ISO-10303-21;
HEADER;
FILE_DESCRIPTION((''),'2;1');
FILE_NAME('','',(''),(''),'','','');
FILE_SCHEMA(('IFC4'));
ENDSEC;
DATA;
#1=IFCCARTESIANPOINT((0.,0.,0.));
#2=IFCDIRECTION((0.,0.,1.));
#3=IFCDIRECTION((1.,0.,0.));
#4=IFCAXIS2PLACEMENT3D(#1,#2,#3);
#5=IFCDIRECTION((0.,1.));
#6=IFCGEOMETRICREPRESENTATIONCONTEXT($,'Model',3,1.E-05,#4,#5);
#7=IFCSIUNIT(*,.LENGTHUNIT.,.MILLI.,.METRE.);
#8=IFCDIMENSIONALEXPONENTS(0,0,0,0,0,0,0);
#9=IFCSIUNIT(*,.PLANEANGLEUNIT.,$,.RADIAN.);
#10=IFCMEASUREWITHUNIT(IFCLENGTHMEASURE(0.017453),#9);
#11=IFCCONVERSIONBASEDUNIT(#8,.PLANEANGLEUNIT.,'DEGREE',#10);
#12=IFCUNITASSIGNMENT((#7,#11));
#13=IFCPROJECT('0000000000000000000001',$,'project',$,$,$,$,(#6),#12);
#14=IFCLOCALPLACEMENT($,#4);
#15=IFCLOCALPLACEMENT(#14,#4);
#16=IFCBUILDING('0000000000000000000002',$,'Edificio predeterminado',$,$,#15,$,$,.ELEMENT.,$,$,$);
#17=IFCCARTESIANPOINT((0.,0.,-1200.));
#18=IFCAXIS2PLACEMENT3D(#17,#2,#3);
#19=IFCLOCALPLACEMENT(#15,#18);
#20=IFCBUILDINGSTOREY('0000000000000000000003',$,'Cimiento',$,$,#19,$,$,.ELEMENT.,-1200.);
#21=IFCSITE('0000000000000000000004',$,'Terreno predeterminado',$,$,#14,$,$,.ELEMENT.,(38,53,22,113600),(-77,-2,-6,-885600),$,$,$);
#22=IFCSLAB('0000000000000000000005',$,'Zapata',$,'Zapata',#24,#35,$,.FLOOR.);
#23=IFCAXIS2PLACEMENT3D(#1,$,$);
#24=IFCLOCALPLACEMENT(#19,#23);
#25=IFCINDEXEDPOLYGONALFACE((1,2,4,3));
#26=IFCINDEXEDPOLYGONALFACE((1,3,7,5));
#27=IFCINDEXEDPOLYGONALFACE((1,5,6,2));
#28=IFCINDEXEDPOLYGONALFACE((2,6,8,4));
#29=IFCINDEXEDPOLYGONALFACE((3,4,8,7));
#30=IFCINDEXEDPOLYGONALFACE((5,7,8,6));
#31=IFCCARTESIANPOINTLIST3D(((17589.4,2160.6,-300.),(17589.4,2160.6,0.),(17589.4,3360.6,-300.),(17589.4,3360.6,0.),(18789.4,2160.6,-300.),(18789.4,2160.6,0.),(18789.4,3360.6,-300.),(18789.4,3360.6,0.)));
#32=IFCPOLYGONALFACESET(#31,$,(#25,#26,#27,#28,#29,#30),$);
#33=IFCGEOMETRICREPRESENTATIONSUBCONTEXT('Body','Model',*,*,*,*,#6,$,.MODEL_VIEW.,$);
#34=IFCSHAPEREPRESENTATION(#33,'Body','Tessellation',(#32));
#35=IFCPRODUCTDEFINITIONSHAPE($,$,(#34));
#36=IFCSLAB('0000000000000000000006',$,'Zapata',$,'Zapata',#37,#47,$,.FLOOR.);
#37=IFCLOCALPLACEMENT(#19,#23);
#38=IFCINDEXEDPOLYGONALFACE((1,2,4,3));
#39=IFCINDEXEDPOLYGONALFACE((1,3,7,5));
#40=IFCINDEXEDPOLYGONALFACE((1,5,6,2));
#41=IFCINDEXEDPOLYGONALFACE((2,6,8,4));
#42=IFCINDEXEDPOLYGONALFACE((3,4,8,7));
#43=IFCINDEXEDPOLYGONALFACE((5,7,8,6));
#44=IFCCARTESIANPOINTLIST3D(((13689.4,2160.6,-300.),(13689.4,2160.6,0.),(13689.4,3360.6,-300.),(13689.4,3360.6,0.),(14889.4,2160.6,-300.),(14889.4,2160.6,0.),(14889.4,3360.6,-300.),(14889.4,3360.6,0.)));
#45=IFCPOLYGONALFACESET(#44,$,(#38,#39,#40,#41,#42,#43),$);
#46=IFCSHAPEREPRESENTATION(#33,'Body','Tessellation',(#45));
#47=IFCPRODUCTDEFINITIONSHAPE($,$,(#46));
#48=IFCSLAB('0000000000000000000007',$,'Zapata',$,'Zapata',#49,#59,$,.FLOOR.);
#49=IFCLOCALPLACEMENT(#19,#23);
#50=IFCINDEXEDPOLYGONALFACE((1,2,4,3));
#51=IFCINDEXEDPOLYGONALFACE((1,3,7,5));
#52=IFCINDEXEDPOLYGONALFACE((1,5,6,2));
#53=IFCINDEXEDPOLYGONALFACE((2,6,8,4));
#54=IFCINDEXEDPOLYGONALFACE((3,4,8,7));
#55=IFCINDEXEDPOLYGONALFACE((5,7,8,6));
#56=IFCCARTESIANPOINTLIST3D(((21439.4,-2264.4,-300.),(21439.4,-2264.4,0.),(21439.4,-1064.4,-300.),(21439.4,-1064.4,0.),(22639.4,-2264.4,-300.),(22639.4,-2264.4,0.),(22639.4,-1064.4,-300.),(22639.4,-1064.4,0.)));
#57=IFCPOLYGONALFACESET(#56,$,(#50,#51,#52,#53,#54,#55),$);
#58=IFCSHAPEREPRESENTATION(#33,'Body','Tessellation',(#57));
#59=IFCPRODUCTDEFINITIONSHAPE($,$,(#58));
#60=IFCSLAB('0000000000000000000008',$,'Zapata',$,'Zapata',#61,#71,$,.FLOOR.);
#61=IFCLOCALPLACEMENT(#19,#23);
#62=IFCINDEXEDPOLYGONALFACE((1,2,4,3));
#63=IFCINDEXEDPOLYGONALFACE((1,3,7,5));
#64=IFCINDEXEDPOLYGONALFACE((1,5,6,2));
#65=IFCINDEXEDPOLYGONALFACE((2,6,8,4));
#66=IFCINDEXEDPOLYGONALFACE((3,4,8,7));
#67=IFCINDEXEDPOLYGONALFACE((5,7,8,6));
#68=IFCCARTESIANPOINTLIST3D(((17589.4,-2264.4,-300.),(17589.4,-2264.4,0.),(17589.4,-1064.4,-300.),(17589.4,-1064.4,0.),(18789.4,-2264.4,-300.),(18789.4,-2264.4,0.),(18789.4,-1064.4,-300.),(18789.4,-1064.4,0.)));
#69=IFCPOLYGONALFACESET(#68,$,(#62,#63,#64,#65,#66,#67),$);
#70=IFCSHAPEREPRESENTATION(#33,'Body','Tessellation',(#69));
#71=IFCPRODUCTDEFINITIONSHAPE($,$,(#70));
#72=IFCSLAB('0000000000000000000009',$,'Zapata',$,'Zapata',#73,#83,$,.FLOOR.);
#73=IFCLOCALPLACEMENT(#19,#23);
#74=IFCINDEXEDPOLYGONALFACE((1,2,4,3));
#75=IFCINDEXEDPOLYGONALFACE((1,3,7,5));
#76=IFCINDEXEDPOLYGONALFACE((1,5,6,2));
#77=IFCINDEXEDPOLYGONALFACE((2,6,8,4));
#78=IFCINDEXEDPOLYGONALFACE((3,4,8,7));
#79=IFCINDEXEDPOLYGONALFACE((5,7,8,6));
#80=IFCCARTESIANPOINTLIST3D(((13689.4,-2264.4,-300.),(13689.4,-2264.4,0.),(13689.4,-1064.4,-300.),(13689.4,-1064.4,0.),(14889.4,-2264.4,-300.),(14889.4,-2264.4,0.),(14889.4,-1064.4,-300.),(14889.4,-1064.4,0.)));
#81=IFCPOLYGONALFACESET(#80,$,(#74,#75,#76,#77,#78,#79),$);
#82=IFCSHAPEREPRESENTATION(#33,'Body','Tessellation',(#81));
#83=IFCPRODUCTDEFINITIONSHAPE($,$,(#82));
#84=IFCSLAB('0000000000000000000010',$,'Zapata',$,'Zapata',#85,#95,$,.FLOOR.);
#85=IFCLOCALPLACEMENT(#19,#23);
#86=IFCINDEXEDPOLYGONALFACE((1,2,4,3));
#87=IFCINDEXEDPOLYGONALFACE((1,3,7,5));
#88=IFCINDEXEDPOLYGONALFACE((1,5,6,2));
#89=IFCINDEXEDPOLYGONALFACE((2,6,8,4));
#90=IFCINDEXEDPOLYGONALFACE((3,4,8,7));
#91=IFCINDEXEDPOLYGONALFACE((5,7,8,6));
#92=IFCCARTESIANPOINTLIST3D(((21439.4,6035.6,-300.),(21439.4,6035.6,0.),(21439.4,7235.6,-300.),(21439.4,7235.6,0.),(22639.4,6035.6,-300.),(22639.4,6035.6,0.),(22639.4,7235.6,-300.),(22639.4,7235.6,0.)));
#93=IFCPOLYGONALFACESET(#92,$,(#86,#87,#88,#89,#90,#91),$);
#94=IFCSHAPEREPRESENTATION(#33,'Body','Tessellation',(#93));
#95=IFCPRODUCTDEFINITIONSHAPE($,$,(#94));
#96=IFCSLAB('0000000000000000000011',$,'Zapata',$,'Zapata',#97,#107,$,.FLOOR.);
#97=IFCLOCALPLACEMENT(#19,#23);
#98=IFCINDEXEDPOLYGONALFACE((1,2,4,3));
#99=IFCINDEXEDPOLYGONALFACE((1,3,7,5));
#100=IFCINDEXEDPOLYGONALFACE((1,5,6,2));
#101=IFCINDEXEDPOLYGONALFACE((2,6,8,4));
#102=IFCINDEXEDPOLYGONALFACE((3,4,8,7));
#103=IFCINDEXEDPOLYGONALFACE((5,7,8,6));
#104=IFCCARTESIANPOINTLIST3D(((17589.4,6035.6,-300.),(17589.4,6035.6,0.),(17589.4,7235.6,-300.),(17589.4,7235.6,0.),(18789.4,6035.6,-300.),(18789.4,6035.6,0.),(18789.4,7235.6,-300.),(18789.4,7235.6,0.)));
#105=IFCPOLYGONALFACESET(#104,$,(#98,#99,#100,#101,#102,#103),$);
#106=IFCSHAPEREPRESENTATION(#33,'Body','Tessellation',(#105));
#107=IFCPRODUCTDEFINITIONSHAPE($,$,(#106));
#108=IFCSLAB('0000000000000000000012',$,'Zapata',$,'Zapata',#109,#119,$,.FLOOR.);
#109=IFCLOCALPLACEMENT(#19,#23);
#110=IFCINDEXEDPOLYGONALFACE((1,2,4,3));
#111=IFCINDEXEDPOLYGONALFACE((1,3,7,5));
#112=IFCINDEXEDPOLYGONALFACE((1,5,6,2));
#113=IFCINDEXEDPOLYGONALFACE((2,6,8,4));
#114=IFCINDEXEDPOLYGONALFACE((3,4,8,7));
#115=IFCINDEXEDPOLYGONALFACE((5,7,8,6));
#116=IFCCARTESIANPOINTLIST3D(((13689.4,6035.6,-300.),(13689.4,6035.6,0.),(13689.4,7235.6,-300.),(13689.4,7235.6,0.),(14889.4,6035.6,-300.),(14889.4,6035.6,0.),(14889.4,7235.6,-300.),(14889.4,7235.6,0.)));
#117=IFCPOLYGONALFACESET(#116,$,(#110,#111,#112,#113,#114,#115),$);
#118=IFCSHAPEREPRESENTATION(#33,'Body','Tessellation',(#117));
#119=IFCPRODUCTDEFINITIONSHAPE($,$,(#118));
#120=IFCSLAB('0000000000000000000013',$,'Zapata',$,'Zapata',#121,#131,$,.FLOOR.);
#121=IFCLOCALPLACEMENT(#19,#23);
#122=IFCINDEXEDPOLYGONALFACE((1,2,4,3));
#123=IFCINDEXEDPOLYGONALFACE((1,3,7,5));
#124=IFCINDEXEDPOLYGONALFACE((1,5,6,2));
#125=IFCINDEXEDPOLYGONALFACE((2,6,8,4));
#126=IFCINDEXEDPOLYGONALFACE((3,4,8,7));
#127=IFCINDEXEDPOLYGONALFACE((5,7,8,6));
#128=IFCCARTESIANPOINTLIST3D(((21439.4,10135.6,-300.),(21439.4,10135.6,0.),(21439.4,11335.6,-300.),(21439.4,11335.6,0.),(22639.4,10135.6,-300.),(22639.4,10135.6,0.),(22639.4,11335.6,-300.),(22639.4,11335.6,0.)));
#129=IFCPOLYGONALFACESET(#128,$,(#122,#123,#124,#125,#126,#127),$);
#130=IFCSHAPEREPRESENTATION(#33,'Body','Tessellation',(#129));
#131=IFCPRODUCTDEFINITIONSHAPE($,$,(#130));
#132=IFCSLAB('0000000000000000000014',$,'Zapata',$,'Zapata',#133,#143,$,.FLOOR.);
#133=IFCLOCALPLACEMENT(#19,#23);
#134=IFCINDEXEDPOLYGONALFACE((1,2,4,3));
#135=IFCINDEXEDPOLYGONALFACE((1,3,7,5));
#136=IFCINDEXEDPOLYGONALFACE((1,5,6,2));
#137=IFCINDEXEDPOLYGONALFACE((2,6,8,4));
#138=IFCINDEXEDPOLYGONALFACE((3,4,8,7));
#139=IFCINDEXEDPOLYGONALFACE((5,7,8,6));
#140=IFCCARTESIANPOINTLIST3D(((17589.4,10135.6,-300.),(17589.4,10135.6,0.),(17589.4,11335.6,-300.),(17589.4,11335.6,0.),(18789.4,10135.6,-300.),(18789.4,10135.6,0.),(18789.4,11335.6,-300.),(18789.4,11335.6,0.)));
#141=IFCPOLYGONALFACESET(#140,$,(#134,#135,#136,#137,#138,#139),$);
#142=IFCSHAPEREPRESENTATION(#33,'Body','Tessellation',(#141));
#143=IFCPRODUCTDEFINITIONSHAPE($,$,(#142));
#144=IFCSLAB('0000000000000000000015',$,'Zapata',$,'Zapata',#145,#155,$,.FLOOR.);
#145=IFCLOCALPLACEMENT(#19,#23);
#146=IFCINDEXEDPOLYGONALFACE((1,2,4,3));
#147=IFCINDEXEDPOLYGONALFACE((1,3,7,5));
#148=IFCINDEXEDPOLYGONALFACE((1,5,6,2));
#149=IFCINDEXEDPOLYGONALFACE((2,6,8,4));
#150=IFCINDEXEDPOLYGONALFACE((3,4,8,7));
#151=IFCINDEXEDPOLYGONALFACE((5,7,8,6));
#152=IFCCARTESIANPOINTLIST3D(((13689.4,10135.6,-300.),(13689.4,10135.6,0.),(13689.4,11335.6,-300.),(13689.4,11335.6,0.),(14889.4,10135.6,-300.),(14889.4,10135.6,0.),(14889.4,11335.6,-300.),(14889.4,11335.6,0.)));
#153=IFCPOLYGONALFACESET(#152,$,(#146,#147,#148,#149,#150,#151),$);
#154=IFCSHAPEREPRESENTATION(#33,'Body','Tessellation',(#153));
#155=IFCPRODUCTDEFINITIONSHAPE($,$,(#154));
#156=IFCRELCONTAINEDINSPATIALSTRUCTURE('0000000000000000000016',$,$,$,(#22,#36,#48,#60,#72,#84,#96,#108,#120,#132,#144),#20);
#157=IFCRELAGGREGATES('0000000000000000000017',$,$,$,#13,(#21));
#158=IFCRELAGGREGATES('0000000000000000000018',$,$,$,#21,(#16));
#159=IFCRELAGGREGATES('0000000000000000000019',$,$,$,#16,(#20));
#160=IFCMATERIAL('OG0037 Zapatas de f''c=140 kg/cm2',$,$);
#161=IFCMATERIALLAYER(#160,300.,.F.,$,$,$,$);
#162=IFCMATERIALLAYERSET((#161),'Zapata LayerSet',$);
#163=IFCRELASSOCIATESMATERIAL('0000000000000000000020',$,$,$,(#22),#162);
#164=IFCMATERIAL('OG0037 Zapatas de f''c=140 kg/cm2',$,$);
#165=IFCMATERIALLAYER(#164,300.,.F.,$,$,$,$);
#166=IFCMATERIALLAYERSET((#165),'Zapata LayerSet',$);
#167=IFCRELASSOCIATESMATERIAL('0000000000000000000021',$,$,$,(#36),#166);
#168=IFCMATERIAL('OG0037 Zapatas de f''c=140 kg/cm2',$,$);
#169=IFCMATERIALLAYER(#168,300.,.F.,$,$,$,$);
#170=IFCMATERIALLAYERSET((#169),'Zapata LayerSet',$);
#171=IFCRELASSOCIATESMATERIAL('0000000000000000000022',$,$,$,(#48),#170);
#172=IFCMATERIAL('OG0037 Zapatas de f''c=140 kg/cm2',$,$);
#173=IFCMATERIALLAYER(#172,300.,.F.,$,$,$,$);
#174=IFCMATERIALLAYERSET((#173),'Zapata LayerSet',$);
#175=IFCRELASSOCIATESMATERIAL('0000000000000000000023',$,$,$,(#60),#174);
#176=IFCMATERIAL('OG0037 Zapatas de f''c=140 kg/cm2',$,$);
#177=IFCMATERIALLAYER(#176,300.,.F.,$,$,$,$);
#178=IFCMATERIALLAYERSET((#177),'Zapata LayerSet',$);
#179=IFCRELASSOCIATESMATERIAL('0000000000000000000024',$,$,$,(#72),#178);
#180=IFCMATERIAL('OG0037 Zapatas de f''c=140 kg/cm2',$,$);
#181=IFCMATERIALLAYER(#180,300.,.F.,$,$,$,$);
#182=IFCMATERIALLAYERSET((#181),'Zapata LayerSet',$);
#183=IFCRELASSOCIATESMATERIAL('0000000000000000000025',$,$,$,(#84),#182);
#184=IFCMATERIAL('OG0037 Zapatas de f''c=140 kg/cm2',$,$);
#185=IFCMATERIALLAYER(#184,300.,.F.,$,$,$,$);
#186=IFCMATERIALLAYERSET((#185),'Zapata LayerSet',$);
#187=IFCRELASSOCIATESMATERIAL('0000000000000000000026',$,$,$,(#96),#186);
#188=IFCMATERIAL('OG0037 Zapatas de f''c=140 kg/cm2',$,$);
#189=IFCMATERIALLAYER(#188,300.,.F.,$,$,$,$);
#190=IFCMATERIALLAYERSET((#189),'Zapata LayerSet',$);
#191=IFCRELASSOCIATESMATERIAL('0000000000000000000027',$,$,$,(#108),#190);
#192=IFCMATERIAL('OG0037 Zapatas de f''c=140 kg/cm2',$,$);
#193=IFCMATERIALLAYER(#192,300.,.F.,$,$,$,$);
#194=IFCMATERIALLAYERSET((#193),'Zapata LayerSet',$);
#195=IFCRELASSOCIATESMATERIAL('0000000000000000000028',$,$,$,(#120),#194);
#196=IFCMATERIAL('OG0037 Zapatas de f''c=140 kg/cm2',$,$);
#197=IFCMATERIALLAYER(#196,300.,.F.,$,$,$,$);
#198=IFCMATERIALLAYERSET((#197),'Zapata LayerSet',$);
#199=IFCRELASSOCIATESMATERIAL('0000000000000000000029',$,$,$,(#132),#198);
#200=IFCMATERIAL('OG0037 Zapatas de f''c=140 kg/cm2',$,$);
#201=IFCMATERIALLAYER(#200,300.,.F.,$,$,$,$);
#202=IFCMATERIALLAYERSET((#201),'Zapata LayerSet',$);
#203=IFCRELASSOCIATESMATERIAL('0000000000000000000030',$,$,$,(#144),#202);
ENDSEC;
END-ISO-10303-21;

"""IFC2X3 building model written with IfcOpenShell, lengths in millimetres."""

from ifc_helpers import new_model, entity, si_unit, converted_unit, direction, frame, origin_with_axes, place, context, subcontext, project, spatial, polyline, outline, extrude, material, layer, layer_set, layer_usage, element, save


model = new_model("IFC2X3")

# Units and contexts
model_context = context("Model", 3, precision=1e-05, world=origin_with_axes(), true_north=direction((0.0, 1.0)))
body_context = subcontext(model_context, "Body", "Model", "MODEL_VIEW")
ifc_project = project(units=[si_unit("LENGTHUNIT", "METRE", prefix="MILLI"), converted_unit("PLANEANGLEUNIT", "DEGREE", entity("IfcLengthMeasure", 0.017453), si_unit("PLANEANGLEUNIT", "RADIAN"), dimensions=[0, 0, 0, 0, 0, 0, 0])], contexts=[model_context])

# Site, building, storey
site_placement = place(None, origin_with_axes())
site = spatial("IfcSite", under=ifc_project, at=site_placement, Name="Terreno predeterminado", CompositionType="ELEMENT", RefLatitude=(38, 53, 22, 113600), RefLongitude=(-77, -2, -6, -885600))
building_placement = place(site_placement, origin_with_axes())
building = spatial("IfcBuilding", under=site, at=building_placement, Name="Edificio predeterminado", CompositionType="ELEMENT")
storey_placement = place(building_placement, frame((0.0, 0.0, -1200.0), z_axis=(0.0, 0.0, 1.0), x_axis=(1.0, 0.0, 0.0)))
storey = spatial("IfcBuildingStorey", under=building, at=storey_placement, Name="Cimiento", CompositionType="ELEMENT", Elevation=-1200.0)

# Slabs
ifc_material_1 = material(Name="OG0037 Zapatas de f'c=140 kg/cm2")
ifc_layer_1 = layer(ifc_material_1, 300.0, ventilated=False)
ifc_layer_set_1 = layer_set([ifc_layer_1], Name="Zapata LayerSet")
ifc_layer_usage_1 = layer_usage(ifc_layer_set_1, "AXIS3", "POSITIVE", 0.0)
slab_1_placement = place(storey_placement, frame((0.0, 0.0, 1200.0), z_axis=(0.0, 0.0, 1.0), x_axis=(1.0, 0.0, 0.0)))
element("IfcSlab", 1, at=slab_1_placement, inside=storey, material=ifc_layer_usage_1, Name="Zapata", ObjectType="Zapata", PredefinedType="FLOOR", context=body_context, shape_type="SweptSolid", body=[
    extrude(outline(polyline([(0.0, 0.0), (1200.0, 0.0), (1200.0, 1200.0), (0.0, 1200.0), (0.0, 0.0)])), frame((17589.4, 3360.6, -1500.0), z_axis=(0.0, 0.0, -1.0), x_axis=(1.0, 0.0, 0.0)), (0.0, 0.0, -1.0), 300.0),
])
ifc_material_2 = material(Name="OG0037 Zapatas de f'c=140 kg/cm2")
ifc_layer_2 = layer(ifc_material_2, 300.0, ventilated=False)
ifc_layer_set_2 = layer_set([ifc_layer_2], Name="Zapata LayerSet")
ifc_layer_usage_2 = layer_usage(ifc_layer_set_2, "AXIS3", "POSITIVE", 0.0)
slab_2_placement = place(storey_placement, frame((0.0, 0.0, 1200.0), z_axis=(0.0, 0.0, 1.0), x_axis=(1.0, 0.0, 0.0)))
element("IfcSlab", 2, at=slab_2_placement, inside=storey, material=ifc_layer_usage_2, Name="Zapata", ObjectType="Zapata", PredefinedType="FLOOR", context=body_context, shape_type="SweptSolid", body=[
    extrude(outline(polyline([(0.0, 0.0), (1200.0, 0.0), (1200.0, 1200.0), (0.0, 1200.0), (0.0, 0.0)])), frame((13689.4, 3360.6, -1500.0), z_axis=(0.0, 0.0, -1.0), x_axis=(1.0, 0.0, 0.0)), (0.0, 0.0, -1.0), 300.0),
])
ifc_material_3 = material(Name="OG0037 Zapatas de f'c=140 kg/cm2")
ifc_layer_3 = layer(ifc_material_3, 300.0, ventilated=False)
ifc_layer_set_3 = layer_set([ifc_layer_3], Name="Zapata LayerSet")
ifc_layer_usage_3 = layer_usage(ifc_layer_set_3, "AXIS3", "POSITIVE", 0.0)
slab_3_placement = place(storey_placement, frame((0.0, 0.0, 1200.0), z_axis=(0.0, 0.0, 1.0), x_axis=(1.0, 0.0, 0.0)))
element("IfcSlab", 3, at=slab_3_placement, inside=storey, material=ifc_layer_usage_3, Name="Zapata", ObjectType="Zapata", PredefinedType="FLOOR", context=body_context, shape_type="SweptSolid", body=[
    extrude(outline(polyline([(0.0, 0.0), (1200.0, 0.0), (1200.0, 1200.0), (0.0, 1200.0), (0.0, 0.0)])), frame((21439.4, -1064.4, -1500.0), z_axis=(0.0, 0.0, -1.0), x_axis=(1.0, 0.0, 0.0)), (0.0, 0.0, -1.0), 300.0),
])
ifc_material_4 = material(Name="OG0037 Zapatas de f'c=140 kg/cm2")
ifc_layer_4 = layer(ifc_material_4, 300.0, ventilated=False)
ifc_layer_set_4 = layer_set([ifc_layer_4], Name="Zapata LayerSet")
ifc_layer_usage_4 = layer_usage(ifc_layer_set_4, "AXIS3", "POSITIVE", 0.0)
slab_4_placement = place(storey_placement, frame((0.0, 0.0, 1200.0), z_axis=(0.0, 0.0, 1.0), x_axis=(1.0, 0.0, 0.0)))
element("IfcSlab", 4, at=slab_4_placement, inside=storey, material=ifc_layer_usage_4, Name="Zapata", ObjectType="Zapata", PredefinedType="FLOOR", context=body_context, shape_type="SweptSolid", body=[
    extrude(outline(polyline([(0.0, 0.0), (1200.0, 0.0), (1200.0, 1200.0), (0.0, 1200.0), (0.0, 0.0)])), frame((17589.4, -1064.4, -1500.0), z_axis=(0.0, 0.0, -1.0), x_axis=(1.0, 0.0, 0.0)), (0.0, 0.0, -1.0), 300.0),
])
ifc_material_5 = material(Name="OG0037 Zapatas de f'c=140 kg/cm2")
ifc_layer_5 = layer(ifc_material_5, 300.0, ventilated=False)
ifc_layer_set_5 = layer_set([ifc_layer_5], Name="Zapata LayerSet")
ifc_layer_usage_5 = layer_usage(ifc_layer_set_5, "AXIS3", "POSITIVE", 0.0)
slab_5_placement = place(storey_placement, frame((0.0, 0.0, 1200.0), z_axis=(0.0, 0.0, 1.0), x_axis=(1.0, 0.0, 0.0)))
element("IfcSlab", 5, at=slab_5_placement, inside=storey, material=ifc_layer_usage_5, Name="Zapata", ObjectType="Zapata", PredefinedType="FLOOR", context=body_context, shape_type="SweptSolid", body=[
    extrude(outline(polyline([(0.0, 0.0), (1200.0, 0.0), (1200.0, 1200.0), (0.0, 1200.0), (0.0, 0.0)])), frame((13689.4, -1064.4, -1500.0), z_axis=(0.0, 0.0, -1.0), x_axis=(1.0, 0.0, 0.0)), (0.0, 0.0, -1.0), 300.0),
])
ifc_material_6 = material(Name="OG0037 Zapatas de f'c=140 kg/cm2")
ifc_layer_6 = layer(ifc_material_6, 300.0, ventilated=False)
ifc_layer_set_6 = layer_set([ifc_layer_6], Name="Zapata LayerSet")
ifc_layer_usage_6 = layer_usage(ifc_layer_set_6, "AXIS3", "POSITIVE", 0.0)
slab_6_placement = place(storey_placement, frame((0.0, 0.0, 1200.0), z_axis=(0.0, 0.0, 1.0), x_axis=(1.0, 0.0, 0.0)))
element("IfcSlab", 6, at=slab_6_placement, inside=storey, material=ifc_layer_usage_6, Name="Zapata", ObjectType="Zapata", PredefinedType="FLOOR", context=body_context, shape_type="SweptSolid", body=[
    extrude(outline(polyline([(0.0, 0.0), (1200.0, 0.0), (1200.0, 1200.0), (0.0, 1200.0), (0.0, 0.0)])), frame((21439.4, 7235.6, -1500.0), z_axis=(0.0, 0.0, -1.0), x_axis=(1.0, 0.0, 0.0)), (0.0, 0.0, -1.0), 300.0),
])
ifc_material_7 = material(Name="OG0037 Zapatas de f'c=140 kg/cm2")
ifc_layer_7 = layer(ifc_material_7, 300.0, ventilated=False)
ifc_layer_set_7 = layer_set([ifc_layer_7], Name="Zapata LayerSet")
ifc_layer_usage_7 = layer_usage(ifc_layer_set_7, "AXIS3", "POSITIVE", 0.0)
slab_7_placement = place(storey_placement, frame((0.0, 0.0, 1200.0), z_axis=(0.0, 0.0, 1.0), x_axis=(1.0, 0.0, 0.0)))
element("IfcSlab", 7, at=slab_7_placement, inside=storey, material=ifc_layer_usage_7, Name="Zapata", ObjectType="Zapata", PredefinedType="FLOOR", context=body_context, shape_type="SweptSolid", body=[
    extrude(outline(polyline([(0.0, 0.0), (1200.0, 0.0), (1200.0, 1200.0), (0.0, 1200.0), (0.0, 0.0)])), frame((17589.4, 7235.6, -1500.0), z_axis=(0.0, 0.0, -1.0), x_axis=(1.0, 0.0, 0.0)), (0.0, 0.0, -1.0), 300.0),
])
ifc_material_8 = material(Name="OG0037 Zapatas de f'c=140 kg/cm2")
ifc_layer_8 = layer(ifc_material_8, 300.0, ventilated=False)
ifc_layer_set_8 = layer_set([ifc_layer_8], Name="Zapata LayerSet")
ifc_layer_usage_8 = layer_usage(ifc_layer_set_8, "AXIS3", "POSITIVE", 0.0)
slab_8_placement = place(storey_placement, frame((0.0, 0.0, 1200.0), z_axis=(0.0, 0.0, 1.0), x_axis=(1.0, 0.0, 0.0)))
element("IfcSlab", 8, at=slab_8_placement, inside=storey, material=ifc_layer_usage_8, Name="Zapata", ObjectType="Zapata", PredefinedType="FLOOR", context=body_context, shape_type="SweptSolid", body=[
    extrude(outline(polyline([(0.0, 0.0), (1200.0, 0.0), (1200.0, 1200.0), (0.0, 1200.0), (0.0, 0.0)])), frame((13689.4, 7235.6, -1500.0), z_axis=(0.0, 0.0, -1.0), x_axis=(1.0, 0.0, 0.0)), (0.0, 0.0, -1.0), 300.0),
])
ifc_material_9 = material(Name="OG0037 Zapatas de f'c=140 kg/cm2")
ifc_layer_9 = layer(ifc_material_9, 300.0, ventilated=False)
ifc_layer_set_9 = layer_set([ifc_layer_9], Name="Zapata LayerSet")
ifc_layer_usage_9 = layer_usage(ifc_layer_set_9, "AXIS3", "POSITIVE", 0.0)
slab_9_placement = place(storey_placement, frame((0.0, 0.0, 1200.0), z_axis=(0.0, 0.0, 1.0), x_axis=(1.0, 0.0, 0.0)))
element("IfcSlab", 9, at=slab_9_placement, inside=storey, material=ifc_layer_usage_9, Name="Zapata", ObjectType="Zapata", PredefinedType="FLOOR", context=body_context, shape_type="SweptSolid", body=[
    extrude(outline(polyline([(0.0, 0.0), (1200.0, 0.0), (1200.0, 1200.0), (0.0, 1200.0), (0.0, 0.0)])), frame((21439.4, 11335.6, -1500.0), z_axis=(0.0, 0.0, -1.0), x_axis=(1.0, 0.0, 0.0)), (0.0, 0.0, -1.0), 300.0),
])
ifc_material_10 = material(Name="OG0037 Zapatas de f'c=140 kg/cm2")
ifc_layer_10 = layer(ifc_material_10, 300.0, ventilated=False)
ifc_layer_set_10 = layer_set([ifc_layer_10], Name="Zapata LayerSet")
ifc_layer_usage_10 = layer_usage(ifc_layer_set_10, "AXIS3", "POSITIVE", 0.0)
slab_10_placement = place(storey_placement, frame((0.0, 0.0, 1200.0), z_axis=(0.0, 0.0, 1.0), x_axis=(1.0, 0.0, 0.0)))
element("IfcSlab", 10, at=slab_10_placement, inside=storey, material=ifc_layer_usage_10, Name="Zapata", ObjectType="Zapata", PredefinedType="FLOOR", context=body_context, shape_type="SweptSolid", body=[
    extrude(outline(polyline([(0.0, 0.0), (1200.0, 0.0), (1200.0, 1200.0), (0.0, 1200.0), (0.0, 0.0)])), frame((17589.4, 11335.6, -1500.0), z_axis=(0.0, 0.0, -1.0), x_axis=(1.0, 0.0, 0.0)), (0.0, 0.0, -1.0), 300.0),
])
ifc_material_11 = material(Name="OG0037 Zapatas de f'c=140 kg/cm2")
ifc_layer_11 = layer(ifc_material_11, 300.0, ventilated=False)
ifc_layer_set_11 = layer_set([ifc_layer_11], Name="Zapata LayerSet")
ifc_layer_usage_11 = layer_usage(ifc_layer_set_11, "AXIS3", "POSITIVE", 0.0)
slab_11_placement = place(storey_placement, frame((0.0, 0.0, 1200.0), z_axis=(0.0, 0.0, 1.0), x_axis=(1.0, 0.0, 0.0)))
element("IfcSlab", 11, at=slab_11_placement, inside=storey, material=ifc_layer_usage_11, Name="Zapata", ObjectType="Zapata", PredefinedType="FLOOR", context=body_context, shape_type="SweptSolid", body=[
    extrude(outline(polyline([(0.0, 0.0), (1200.0, 0.0), (1200.0, 1200.0), (0.0, 1200.0), (0.0, 0.0)])), frame((13689.4, 11335.6, -1500.0), z_axis=(0.0, 0.0, -1.0), x_axis=(1.0, 0.0, 0.0)), (0.0, 0.0, -1.0), 300.0),
])

save(model, "model.ifc")
